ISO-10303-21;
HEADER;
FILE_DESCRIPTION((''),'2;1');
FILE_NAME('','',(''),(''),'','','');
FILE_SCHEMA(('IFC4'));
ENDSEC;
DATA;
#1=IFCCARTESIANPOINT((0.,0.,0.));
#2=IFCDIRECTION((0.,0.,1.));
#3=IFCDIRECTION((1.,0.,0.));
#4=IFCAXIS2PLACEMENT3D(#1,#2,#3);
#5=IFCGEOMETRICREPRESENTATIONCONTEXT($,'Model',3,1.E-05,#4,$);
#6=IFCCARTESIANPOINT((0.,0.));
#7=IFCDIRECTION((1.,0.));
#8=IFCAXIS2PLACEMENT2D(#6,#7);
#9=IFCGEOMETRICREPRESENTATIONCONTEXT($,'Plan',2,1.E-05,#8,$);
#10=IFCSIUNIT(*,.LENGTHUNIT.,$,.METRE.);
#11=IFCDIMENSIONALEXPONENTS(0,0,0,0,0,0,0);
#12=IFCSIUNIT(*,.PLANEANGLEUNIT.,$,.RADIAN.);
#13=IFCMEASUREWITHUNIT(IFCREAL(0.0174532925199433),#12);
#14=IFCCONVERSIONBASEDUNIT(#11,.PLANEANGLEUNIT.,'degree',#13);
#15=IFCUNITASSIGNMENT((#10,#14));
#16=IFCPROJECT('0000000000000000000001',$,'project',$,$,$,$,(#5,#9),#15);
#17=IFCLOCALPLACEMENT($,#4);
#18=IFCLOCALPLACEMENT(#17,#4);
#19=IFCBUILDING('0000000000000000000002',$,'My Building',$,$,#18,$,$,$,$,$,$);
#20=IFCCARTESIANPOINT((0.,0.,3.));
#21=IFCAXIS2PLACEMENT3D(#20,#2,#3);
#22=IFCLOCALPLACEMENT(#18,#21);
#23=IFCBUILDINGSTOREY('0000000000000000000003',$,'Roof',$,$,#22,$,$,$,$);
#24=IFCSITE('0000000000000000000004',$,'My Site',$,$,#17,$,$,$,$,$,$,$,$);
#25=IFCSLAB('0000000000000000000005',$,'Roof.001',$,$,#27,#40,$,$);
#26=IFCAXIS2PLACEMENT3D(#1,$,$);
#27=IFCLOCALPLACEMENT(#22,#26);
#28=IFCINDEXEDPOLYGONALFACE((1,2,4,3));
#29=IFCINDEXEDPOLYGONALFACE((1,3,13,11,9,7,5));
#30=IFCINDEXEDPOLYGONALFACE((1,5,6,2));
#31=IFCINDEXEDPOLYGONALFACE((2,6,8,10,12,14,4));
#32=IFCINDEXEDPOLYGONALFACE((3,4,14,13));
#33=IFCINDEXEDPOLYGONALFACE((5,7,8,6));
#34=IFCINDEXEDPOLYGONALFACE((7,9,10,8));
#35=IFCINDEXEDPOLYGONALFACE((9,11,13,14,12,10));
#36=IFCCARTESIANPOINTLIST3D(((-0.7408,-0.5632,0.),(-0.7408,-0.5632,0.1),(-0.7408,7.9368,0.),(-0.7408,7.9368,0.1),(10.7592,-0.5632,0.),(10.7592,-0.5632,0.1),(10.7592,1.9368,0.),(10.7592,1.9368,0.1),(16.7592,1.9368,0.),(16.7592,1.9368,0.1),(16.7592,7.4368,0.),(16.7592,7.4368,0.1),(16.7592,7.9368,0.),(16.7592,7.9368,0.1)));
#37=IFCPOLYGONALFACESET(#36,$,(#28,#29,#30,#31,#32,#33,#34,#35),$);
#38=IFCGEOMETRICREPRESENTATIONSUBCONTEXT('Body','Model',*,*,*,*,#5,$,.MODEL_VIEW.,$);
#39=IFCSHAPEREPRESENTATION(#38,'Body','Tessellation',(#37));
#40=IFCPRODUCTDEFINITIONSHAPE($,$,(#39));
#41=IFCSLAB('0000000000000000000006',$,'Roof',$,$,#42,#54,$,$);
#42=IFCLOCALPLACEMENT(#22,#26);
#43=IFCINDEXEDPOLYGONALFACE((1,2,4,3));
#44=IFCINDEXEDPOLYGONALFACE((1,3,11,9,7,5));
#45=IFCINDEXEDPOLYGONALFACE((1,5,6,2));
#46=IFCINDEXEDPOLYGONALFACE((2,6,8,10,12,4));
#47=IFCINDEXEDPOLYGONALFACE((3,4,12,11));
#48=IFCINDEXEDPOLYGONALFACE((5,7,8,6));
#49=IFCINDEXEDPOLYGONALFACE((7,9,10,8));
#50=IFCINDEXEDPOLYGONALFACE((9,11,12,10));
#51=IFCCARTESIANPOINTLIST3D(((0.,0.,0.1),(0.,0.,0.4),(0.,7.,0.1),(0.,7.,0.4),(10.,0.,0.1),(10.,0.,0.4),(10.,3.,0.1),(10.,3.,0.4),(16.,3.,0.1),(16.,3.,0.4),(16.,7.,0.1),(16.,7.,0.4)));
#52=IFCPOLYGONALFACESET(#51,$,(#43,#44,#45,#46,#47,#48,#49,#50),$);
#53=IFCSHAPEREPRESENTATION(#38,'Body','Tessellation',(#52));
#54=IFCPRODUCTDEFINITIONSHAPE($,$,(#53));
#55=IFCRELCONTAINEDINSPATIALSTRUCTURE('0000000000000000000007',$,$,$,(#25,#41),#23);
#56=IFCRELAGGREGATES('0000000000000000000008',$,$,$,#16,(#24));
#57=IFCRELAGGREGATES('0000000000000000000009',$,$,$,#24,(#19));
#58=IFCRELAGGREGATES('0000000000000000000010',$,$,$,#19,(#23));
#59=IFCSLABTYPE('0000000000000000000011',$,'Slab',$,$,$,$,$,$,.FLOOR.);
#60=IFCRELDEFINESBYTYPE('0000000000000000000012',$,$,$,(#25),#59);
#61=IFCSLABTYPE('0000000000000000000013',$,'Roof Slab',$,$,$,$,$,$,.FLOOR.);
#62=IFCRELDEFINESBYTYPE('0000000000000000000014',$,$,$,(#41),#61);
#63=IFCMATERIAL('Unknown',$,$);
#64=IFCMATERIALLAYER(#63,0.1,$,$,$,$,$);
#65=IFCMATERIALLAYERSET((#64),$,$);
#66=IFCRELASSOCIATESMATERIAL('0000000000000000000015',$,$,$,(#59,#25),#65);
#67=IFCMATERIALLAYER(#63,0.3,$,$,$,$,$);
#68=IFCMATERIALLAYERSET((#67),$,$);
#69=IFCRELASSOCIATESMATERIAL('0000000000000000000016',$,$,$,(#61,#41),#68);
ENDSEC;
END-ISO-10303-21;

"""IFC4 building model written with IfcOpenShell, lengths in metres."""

from ifc_helpers import new_model, entity, si_unit, converted_unit, frame, origin_with_axes, origin_2d_with_axis, place, context, subcontext, project, spatial, indexed_curve, outline, extrude, material, layer, layer_set, layer_usage, type_object, element, save


model = new_model("IFC4")

# Units and contexts
model_context = context("Model", 3, precision=1e-05, world=origin_with_axes())
plan_context = context("Plan", 2, precision=1e-05, world=origin_2d_with_axis())
body_context = subcontext(model_context, "Body", "Model", "MODEL_VIEW")
ifc_project = project(units=[si_unit("LENGTHUNIT", "METRE"), converted_unit("PLANEANGLEUNIT", "degree", entity("IfcReal", 0.0174532925199433), si_unit("PLANEANGLEUNIT", "RADIAN"), dimensions=[0, 0, 0, 0, 0, 0, 0])], contexts=[model_context, plan_context])

# Site, building, storey
site_placement = place(None, origin_with_axes())
site = spatial("IfcSite", under=ifc_project, at=site_placement, Name="My Site")
building_placement = place(site_placement, origin_with_axes())
building = spatial("IfcBuilding", under=site, at=building_placement, Name="My Building")
storey_placement = place(building_placement, frame((0.0, 0.0, 3.0), z_axis=(0.0, 0.0, 1.0), x_axis=(1.0, 0.0, 0.0)))
storey = spatial("IfcBuildingStorey", under=building, at=storey_placement, Name="Roof")

# Slabs
ifc_material = material(Name="Unknown")
ifc_layer_1 = layer(ifc_material, 0.1)
ifc_layer_set_1 = layer_set([ifc_layer_1])
ifc_layer_usage_1 = layer_usage(ifc_layer_set_1, "AXIS3", "POSITIVE", -0.1)
slab_type_1 = type_object("IfcSlabType", Name="Slab", PredefinedType="FLOOR", material=ifc_layer_set_1)
slab_1_placement = place(storey_placement, frame((-0.7408, 7.9368, 0.1), z_axis=(0.0, 0.0, 1.0), x_axis=(1.0, 0.0, 0.0)))
element("IfcSlab", 1, at=slab_1_placement, inside=storey, type_object=slab_type_1, material=ifc_layer_usage_1, Name="Roof.001", context=body_context, shape_type="SweptSolid", body=[
    extrude(outline(indexed_curve([(0.0, 0.0), (0.0, -8.5), (11.5, -8.5), (11.5, -6.0), (17.5, -6.0), (17.5, -0.5), (17.5, 0.0), (0.0, 0.0)])), frame((0.0, 0.0, -0.1), z_axis=(0.0, 0.0, 1.0), x_axis=(1.0, 0.0, 0.0)), (0.0, 0.0, 1.0), 0.1),
])
ifc_layer_2 = layer(ifc_material, 0.3)
ifc_layer_set_2 = layer_set([ifc_layer_2])
ifc_layer_usage_2 = layer_usage(ifc_layer_set_2, "AXIS3", "POSITIVE", -0.1)
slab_type_2 = type_object("IfcSlabType", Name="Roof Slab", PredefinedType="FLOOR", material=ifc_layer_set_2)
slab_2_placement = place(storey_placement, frame((0.0, 7.0, 0.2), z_axis=(0.0, 0.0, 1.0), x_axis=(1.0, 0.0, 0.0)))
element("IfcSlab", 2, at=slab_2_placement, inside=storey, type_object=slab_type_2, material=ifc_layer_usage_2, Name="Roof", context=body_context, shape_type="SweptSolid", body=[
    extrude(outline(indexed_curve([(0.0, 0.0), (0.0, -7.0), (10.0, -7.0), (10.0, -4.0), (16.0, -4.0), (16.0, 0.0), (0.0, 0.0)])), frame((0.0, 0.0, -0.1), z_axis=(0.0, 0.0, 1.0), x_axis=(1.0, 0.0, 0.0)), (0.0, 0.0, 1.0), 0.3),
])

save(model, "model.ifc")
